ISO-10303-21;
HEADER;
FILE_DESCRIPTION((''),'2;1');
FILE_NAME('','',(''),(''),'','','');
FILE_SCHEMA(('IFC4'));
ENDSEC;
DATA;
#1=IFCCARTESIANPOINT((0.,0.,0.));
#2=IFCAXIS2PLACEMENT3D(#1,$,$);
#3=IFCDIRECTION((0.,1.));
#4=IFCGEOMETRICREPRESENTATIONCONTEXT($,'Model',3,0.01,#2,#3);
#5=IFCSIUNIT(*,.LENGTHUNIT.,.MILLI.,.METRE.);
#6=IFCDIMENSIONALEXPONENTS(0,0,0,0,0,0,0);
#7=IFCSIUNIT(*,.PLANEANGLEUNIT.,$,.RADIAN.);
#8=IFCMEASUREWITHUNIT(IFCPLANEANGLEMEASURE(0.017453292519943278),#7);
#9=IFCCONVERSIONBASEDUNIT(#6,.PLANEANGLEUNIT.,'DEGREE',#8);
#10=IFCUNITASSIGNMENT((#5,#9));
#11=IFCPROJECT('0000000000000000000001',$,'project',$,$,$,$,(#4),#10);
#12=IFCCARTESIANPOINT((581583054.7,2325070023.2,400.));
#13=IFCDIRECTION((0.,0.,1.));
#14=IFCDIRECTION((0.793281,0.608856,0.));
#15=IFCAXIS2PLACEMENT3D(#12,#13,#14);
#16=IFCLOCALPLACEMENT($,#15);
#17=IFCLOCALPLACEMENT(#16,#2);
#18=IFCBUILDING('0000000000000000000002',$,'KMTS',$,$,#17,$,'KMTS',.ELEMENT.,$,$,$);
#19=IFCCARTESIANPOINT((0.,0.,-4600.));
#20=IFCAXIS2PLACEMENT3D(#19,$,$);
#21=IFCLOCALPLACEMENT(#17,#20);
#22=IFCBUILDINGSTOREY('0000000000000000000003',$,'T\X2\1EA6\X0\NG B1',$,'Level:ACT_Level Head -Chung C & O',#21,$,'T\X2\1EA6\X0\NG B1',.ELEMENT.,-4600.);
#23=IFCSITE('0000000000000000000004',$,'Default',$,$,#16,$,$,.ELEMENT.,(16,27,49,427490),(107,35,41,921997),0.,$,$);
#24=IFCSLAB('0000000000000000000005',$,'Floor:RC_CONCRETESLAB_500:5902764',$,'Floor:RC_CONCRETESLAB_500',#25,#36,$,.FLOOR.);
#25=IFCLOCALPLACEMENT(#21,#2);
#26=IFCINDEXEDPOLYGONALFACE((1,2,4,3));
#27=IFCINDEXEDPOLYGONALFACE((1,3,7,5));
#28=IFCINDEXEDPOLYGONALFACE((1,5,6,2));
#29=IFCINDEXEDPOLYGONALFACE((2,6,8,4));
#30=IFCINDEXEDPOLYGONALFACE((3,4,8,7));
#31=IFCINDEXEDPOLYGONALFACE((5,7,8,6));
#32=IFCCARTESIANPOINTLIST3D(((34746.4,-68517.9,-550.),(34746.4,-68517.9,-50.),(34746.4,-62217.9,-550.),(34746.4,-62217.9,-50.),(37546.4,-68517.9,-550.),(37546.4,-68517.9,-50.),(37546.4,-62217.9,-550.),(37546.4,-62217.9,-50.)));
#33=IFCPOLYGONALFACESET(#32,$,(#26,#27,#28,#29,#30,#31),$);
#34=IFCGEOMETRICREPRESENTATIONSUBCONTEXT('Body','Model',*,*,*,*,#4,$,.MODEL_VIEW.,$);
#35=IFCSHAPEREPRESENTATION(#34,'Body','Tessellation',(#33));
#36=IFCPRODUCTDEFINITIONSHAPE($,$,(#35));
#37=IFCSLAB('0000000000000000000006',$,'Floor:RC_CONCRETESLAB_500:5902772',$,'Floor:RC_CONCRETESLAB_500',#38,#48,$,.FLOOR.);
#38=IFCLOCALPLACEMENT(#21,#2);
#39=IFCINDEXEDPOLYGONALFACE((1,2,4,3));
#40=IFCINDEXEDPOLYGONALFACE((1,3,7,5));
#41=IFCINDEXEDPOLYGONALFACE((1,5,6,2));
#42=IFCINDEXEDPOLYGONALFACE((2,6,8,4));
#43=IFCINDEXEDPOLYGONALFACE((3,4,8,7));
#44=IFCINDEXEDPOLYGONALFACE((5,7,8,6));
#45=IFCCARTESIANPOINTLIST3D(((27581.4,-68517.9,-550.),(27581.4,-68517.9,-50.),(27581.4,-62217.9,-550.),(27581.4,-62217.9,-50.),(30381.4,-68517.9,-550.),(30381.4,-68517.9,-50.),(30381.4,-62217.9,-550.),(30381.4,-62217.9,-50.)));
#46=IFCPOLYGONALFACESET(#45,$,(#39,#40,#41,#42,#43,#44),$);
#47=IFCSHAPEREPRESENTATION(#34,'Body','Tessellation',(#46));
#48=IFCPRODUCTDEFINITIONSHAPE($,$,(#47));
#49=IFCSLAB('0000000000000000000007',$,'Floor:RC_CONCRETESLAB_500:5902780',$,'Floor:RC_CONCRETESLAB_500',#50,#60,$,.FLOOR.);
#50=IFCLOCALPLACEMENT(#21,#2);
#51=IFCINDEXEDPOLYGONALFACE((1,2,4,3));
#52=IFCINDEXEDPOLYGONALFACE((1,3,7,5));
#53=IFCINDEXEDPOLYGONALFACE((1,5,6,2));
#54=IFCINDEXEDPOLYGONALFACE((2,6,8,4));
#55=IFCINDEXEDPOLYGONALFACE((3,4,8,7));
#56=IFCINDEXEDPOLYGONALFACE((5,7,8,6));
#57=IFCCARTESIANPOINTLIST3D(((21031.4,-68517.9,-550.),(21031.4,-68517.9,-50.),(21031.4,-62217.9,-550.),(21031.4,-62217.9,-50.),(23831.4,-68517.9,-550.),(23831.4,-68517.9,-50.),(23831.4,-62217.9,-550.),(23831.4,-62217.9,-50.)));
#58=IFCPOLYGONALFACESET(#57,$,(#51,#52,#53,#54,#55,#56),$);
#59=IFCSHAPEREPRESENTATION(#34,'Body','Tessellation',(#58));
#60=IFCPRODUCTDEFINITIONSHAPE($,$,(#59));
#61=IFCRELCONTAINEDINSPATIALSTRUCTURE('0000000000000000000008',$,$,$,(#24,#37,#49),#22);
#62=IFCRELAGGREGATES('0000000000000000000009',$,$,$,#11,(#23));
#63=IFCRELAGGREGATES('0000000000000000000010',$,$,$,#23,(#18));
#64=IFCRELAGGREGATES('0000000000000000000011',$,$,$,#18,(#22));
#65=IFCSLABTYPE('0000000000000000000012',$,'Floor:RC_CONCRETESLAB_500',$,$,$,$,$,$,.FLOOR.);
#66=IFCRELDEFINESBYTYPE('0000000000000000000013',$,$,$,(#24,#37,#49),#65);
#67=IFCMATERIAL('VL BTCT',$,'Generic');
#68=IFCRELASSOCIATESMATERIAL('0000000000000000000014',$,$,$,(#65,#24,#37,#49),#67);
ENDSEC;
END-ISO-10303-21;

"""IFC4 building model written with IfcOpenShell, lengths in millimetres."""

from ifc_helpers import new_model, entity, si_unit, converted_unit, direction, frame, origin, place, context, subcontext, project, spatial, indexed_curve, outline, extrude, material, type_object, element, save


model = new_model("IFC4")

# Units and contexts
model_context = context("Model", 3, precision=0.01, world=origin(), true_north=direction((0.0, 1.0)))
body_context = subcontext(model_context, "Body", "Model", "MODEL_VIEW")
ifc_project = project(units=[si_unit("LENGTHUNIT", "METRE", prefix="MILLI"), converted_unit("PLANEANGLEUNIT", "DEGREE", entity("IfcPlaneAngleMeasure", 0.017453292519943278), si_unit("PLANEANGLEUNIT", "RADIAN"), dimensions=[0, 0, 0, 0, 0, 0, 0])], contexts=[model_context])

# Site, building, storey
site_placement = place(None, frame((581583054.7, 2325070023.2, 400.0), z_axis=(0.0, 0.0, 1.0), x_axis=(0.793281, 0.608856, 0.0)))
site = spatial("IfcSite", under=ifc_project, at=site_placement, Name="Default", CompositionType="ELEMENT", RefLatitude=(16, 27, 49, 427490), RefLongitude=(107, 35, 41, 921997), RefElevation=0.0)
building_placement = place(site_placement, origin())
building = spatial("IfcBuilding", under=site, at=building_placement, Name="KMTS", LongName="KMTS", CompositionType="ELEMENT")
storey_placement = place(building_placement, frame((0.0, 0.0, -4600.0)))
storey = spatial("IfcBuildingStorey", under=building, at=storey_placement, Name="TẦNG B1", ObjectType="Level:ACT_Level Head -Chung C & O", LongName="TẦNG B1", CompositionType="ELEMENT", Elevation=-4600.0)

# Shared definitions
ifc_material = material(Name="VL BTCT", Category="Generic")

# Slabs
slab_type_1 = type_object("IfcSlabType", Name="Floor:RC_CONCRETESLAB_500", PredefinedType="FLOOR", material=ifc_material)
slab_1_placement = place(storey_placement, origin())
element("IfcSlab", 1, at=slab_1_placement, inside=storey, type_object=slab_type_1, material=ifc_material, Name="Floor:RC_CONCRETESLAB_500:5902764", ObjectType="Floor:RC_CONCRETESLAB_500", PredefinedType="FLOOR", context=body_context, shape_type="SweptSolid", body=[
    extrude(outline(indexed_curve([(-3150.0, -1400.0), (3150.0, -1400.0), (3150.0, 1400.0), (-3150.0, 1400.0), (-3150.0, -1400.0)], self_intersect=False)), frame((36146.4, -65367.9, -50.0), z_axis=(0.0, 0.0, -1.0), x_axis=(0.0, 1.0, 0.0)), (0.0, 0.0, 1.0), 500.0),
])
slab_2_placement = place(storey_placement, origin())
element("IfcSlab", 2, at=slab_2_placement, inside=storey, type_object=slab_type_1, material=ifc_material, Name="Floor:RC_CONCRETESLAB_500:5902772", ObjectType="Floor:RC_CONCRETESLAB_500", PredefinedType="FLOOR", context=body_context, shape_type="SweptSolid", body=[
    extrude(outline(indexed_curve([(-3150.0, -1400.0), (3150.0, -1400.0), (3150.0, 1400.0), (-3150.0, 1400.0), (-3150.0, -1400.0)], self_intersect=False)), frame((28981.4, -65367.9, -50.0), z_axis=(0.0, 0.0, -1.0), x_axis=(0.0, 1.0, 0.0)), (0.0, 0.0, 1.0), 500.0),
])
slab_3_placement = place(storey_placement, origin())
element("IfcSlab", 3, at=slab_3_placement, inside=storey, type_object=slab_type_1, material=ifc_material, Name="Floor:RC_CONCRETESLAB_500:5902780", ObjectType="Floor:RC_CONCRETESLAB_500", PredefinedType="FLOOR", context=body_context, shape_type="SweptSolid", body=[
    extrude(outline(indexed_curve([(-3150.0, -1400.0), (3150.0, -1400.0), (3150.0, 1400.0), (-3150.0, 1400.0), (-3150.0, -1400.0)], self_intersect=False)), frame((22431.4, -65367.9, -50.0), z_axis=(0.0, 0.0, -1.0), x_axis=(0.0, 1.0, 0.0)), (0.0, 0.0, 1.0), 500.0),
])

save(model, "model.ifc")
